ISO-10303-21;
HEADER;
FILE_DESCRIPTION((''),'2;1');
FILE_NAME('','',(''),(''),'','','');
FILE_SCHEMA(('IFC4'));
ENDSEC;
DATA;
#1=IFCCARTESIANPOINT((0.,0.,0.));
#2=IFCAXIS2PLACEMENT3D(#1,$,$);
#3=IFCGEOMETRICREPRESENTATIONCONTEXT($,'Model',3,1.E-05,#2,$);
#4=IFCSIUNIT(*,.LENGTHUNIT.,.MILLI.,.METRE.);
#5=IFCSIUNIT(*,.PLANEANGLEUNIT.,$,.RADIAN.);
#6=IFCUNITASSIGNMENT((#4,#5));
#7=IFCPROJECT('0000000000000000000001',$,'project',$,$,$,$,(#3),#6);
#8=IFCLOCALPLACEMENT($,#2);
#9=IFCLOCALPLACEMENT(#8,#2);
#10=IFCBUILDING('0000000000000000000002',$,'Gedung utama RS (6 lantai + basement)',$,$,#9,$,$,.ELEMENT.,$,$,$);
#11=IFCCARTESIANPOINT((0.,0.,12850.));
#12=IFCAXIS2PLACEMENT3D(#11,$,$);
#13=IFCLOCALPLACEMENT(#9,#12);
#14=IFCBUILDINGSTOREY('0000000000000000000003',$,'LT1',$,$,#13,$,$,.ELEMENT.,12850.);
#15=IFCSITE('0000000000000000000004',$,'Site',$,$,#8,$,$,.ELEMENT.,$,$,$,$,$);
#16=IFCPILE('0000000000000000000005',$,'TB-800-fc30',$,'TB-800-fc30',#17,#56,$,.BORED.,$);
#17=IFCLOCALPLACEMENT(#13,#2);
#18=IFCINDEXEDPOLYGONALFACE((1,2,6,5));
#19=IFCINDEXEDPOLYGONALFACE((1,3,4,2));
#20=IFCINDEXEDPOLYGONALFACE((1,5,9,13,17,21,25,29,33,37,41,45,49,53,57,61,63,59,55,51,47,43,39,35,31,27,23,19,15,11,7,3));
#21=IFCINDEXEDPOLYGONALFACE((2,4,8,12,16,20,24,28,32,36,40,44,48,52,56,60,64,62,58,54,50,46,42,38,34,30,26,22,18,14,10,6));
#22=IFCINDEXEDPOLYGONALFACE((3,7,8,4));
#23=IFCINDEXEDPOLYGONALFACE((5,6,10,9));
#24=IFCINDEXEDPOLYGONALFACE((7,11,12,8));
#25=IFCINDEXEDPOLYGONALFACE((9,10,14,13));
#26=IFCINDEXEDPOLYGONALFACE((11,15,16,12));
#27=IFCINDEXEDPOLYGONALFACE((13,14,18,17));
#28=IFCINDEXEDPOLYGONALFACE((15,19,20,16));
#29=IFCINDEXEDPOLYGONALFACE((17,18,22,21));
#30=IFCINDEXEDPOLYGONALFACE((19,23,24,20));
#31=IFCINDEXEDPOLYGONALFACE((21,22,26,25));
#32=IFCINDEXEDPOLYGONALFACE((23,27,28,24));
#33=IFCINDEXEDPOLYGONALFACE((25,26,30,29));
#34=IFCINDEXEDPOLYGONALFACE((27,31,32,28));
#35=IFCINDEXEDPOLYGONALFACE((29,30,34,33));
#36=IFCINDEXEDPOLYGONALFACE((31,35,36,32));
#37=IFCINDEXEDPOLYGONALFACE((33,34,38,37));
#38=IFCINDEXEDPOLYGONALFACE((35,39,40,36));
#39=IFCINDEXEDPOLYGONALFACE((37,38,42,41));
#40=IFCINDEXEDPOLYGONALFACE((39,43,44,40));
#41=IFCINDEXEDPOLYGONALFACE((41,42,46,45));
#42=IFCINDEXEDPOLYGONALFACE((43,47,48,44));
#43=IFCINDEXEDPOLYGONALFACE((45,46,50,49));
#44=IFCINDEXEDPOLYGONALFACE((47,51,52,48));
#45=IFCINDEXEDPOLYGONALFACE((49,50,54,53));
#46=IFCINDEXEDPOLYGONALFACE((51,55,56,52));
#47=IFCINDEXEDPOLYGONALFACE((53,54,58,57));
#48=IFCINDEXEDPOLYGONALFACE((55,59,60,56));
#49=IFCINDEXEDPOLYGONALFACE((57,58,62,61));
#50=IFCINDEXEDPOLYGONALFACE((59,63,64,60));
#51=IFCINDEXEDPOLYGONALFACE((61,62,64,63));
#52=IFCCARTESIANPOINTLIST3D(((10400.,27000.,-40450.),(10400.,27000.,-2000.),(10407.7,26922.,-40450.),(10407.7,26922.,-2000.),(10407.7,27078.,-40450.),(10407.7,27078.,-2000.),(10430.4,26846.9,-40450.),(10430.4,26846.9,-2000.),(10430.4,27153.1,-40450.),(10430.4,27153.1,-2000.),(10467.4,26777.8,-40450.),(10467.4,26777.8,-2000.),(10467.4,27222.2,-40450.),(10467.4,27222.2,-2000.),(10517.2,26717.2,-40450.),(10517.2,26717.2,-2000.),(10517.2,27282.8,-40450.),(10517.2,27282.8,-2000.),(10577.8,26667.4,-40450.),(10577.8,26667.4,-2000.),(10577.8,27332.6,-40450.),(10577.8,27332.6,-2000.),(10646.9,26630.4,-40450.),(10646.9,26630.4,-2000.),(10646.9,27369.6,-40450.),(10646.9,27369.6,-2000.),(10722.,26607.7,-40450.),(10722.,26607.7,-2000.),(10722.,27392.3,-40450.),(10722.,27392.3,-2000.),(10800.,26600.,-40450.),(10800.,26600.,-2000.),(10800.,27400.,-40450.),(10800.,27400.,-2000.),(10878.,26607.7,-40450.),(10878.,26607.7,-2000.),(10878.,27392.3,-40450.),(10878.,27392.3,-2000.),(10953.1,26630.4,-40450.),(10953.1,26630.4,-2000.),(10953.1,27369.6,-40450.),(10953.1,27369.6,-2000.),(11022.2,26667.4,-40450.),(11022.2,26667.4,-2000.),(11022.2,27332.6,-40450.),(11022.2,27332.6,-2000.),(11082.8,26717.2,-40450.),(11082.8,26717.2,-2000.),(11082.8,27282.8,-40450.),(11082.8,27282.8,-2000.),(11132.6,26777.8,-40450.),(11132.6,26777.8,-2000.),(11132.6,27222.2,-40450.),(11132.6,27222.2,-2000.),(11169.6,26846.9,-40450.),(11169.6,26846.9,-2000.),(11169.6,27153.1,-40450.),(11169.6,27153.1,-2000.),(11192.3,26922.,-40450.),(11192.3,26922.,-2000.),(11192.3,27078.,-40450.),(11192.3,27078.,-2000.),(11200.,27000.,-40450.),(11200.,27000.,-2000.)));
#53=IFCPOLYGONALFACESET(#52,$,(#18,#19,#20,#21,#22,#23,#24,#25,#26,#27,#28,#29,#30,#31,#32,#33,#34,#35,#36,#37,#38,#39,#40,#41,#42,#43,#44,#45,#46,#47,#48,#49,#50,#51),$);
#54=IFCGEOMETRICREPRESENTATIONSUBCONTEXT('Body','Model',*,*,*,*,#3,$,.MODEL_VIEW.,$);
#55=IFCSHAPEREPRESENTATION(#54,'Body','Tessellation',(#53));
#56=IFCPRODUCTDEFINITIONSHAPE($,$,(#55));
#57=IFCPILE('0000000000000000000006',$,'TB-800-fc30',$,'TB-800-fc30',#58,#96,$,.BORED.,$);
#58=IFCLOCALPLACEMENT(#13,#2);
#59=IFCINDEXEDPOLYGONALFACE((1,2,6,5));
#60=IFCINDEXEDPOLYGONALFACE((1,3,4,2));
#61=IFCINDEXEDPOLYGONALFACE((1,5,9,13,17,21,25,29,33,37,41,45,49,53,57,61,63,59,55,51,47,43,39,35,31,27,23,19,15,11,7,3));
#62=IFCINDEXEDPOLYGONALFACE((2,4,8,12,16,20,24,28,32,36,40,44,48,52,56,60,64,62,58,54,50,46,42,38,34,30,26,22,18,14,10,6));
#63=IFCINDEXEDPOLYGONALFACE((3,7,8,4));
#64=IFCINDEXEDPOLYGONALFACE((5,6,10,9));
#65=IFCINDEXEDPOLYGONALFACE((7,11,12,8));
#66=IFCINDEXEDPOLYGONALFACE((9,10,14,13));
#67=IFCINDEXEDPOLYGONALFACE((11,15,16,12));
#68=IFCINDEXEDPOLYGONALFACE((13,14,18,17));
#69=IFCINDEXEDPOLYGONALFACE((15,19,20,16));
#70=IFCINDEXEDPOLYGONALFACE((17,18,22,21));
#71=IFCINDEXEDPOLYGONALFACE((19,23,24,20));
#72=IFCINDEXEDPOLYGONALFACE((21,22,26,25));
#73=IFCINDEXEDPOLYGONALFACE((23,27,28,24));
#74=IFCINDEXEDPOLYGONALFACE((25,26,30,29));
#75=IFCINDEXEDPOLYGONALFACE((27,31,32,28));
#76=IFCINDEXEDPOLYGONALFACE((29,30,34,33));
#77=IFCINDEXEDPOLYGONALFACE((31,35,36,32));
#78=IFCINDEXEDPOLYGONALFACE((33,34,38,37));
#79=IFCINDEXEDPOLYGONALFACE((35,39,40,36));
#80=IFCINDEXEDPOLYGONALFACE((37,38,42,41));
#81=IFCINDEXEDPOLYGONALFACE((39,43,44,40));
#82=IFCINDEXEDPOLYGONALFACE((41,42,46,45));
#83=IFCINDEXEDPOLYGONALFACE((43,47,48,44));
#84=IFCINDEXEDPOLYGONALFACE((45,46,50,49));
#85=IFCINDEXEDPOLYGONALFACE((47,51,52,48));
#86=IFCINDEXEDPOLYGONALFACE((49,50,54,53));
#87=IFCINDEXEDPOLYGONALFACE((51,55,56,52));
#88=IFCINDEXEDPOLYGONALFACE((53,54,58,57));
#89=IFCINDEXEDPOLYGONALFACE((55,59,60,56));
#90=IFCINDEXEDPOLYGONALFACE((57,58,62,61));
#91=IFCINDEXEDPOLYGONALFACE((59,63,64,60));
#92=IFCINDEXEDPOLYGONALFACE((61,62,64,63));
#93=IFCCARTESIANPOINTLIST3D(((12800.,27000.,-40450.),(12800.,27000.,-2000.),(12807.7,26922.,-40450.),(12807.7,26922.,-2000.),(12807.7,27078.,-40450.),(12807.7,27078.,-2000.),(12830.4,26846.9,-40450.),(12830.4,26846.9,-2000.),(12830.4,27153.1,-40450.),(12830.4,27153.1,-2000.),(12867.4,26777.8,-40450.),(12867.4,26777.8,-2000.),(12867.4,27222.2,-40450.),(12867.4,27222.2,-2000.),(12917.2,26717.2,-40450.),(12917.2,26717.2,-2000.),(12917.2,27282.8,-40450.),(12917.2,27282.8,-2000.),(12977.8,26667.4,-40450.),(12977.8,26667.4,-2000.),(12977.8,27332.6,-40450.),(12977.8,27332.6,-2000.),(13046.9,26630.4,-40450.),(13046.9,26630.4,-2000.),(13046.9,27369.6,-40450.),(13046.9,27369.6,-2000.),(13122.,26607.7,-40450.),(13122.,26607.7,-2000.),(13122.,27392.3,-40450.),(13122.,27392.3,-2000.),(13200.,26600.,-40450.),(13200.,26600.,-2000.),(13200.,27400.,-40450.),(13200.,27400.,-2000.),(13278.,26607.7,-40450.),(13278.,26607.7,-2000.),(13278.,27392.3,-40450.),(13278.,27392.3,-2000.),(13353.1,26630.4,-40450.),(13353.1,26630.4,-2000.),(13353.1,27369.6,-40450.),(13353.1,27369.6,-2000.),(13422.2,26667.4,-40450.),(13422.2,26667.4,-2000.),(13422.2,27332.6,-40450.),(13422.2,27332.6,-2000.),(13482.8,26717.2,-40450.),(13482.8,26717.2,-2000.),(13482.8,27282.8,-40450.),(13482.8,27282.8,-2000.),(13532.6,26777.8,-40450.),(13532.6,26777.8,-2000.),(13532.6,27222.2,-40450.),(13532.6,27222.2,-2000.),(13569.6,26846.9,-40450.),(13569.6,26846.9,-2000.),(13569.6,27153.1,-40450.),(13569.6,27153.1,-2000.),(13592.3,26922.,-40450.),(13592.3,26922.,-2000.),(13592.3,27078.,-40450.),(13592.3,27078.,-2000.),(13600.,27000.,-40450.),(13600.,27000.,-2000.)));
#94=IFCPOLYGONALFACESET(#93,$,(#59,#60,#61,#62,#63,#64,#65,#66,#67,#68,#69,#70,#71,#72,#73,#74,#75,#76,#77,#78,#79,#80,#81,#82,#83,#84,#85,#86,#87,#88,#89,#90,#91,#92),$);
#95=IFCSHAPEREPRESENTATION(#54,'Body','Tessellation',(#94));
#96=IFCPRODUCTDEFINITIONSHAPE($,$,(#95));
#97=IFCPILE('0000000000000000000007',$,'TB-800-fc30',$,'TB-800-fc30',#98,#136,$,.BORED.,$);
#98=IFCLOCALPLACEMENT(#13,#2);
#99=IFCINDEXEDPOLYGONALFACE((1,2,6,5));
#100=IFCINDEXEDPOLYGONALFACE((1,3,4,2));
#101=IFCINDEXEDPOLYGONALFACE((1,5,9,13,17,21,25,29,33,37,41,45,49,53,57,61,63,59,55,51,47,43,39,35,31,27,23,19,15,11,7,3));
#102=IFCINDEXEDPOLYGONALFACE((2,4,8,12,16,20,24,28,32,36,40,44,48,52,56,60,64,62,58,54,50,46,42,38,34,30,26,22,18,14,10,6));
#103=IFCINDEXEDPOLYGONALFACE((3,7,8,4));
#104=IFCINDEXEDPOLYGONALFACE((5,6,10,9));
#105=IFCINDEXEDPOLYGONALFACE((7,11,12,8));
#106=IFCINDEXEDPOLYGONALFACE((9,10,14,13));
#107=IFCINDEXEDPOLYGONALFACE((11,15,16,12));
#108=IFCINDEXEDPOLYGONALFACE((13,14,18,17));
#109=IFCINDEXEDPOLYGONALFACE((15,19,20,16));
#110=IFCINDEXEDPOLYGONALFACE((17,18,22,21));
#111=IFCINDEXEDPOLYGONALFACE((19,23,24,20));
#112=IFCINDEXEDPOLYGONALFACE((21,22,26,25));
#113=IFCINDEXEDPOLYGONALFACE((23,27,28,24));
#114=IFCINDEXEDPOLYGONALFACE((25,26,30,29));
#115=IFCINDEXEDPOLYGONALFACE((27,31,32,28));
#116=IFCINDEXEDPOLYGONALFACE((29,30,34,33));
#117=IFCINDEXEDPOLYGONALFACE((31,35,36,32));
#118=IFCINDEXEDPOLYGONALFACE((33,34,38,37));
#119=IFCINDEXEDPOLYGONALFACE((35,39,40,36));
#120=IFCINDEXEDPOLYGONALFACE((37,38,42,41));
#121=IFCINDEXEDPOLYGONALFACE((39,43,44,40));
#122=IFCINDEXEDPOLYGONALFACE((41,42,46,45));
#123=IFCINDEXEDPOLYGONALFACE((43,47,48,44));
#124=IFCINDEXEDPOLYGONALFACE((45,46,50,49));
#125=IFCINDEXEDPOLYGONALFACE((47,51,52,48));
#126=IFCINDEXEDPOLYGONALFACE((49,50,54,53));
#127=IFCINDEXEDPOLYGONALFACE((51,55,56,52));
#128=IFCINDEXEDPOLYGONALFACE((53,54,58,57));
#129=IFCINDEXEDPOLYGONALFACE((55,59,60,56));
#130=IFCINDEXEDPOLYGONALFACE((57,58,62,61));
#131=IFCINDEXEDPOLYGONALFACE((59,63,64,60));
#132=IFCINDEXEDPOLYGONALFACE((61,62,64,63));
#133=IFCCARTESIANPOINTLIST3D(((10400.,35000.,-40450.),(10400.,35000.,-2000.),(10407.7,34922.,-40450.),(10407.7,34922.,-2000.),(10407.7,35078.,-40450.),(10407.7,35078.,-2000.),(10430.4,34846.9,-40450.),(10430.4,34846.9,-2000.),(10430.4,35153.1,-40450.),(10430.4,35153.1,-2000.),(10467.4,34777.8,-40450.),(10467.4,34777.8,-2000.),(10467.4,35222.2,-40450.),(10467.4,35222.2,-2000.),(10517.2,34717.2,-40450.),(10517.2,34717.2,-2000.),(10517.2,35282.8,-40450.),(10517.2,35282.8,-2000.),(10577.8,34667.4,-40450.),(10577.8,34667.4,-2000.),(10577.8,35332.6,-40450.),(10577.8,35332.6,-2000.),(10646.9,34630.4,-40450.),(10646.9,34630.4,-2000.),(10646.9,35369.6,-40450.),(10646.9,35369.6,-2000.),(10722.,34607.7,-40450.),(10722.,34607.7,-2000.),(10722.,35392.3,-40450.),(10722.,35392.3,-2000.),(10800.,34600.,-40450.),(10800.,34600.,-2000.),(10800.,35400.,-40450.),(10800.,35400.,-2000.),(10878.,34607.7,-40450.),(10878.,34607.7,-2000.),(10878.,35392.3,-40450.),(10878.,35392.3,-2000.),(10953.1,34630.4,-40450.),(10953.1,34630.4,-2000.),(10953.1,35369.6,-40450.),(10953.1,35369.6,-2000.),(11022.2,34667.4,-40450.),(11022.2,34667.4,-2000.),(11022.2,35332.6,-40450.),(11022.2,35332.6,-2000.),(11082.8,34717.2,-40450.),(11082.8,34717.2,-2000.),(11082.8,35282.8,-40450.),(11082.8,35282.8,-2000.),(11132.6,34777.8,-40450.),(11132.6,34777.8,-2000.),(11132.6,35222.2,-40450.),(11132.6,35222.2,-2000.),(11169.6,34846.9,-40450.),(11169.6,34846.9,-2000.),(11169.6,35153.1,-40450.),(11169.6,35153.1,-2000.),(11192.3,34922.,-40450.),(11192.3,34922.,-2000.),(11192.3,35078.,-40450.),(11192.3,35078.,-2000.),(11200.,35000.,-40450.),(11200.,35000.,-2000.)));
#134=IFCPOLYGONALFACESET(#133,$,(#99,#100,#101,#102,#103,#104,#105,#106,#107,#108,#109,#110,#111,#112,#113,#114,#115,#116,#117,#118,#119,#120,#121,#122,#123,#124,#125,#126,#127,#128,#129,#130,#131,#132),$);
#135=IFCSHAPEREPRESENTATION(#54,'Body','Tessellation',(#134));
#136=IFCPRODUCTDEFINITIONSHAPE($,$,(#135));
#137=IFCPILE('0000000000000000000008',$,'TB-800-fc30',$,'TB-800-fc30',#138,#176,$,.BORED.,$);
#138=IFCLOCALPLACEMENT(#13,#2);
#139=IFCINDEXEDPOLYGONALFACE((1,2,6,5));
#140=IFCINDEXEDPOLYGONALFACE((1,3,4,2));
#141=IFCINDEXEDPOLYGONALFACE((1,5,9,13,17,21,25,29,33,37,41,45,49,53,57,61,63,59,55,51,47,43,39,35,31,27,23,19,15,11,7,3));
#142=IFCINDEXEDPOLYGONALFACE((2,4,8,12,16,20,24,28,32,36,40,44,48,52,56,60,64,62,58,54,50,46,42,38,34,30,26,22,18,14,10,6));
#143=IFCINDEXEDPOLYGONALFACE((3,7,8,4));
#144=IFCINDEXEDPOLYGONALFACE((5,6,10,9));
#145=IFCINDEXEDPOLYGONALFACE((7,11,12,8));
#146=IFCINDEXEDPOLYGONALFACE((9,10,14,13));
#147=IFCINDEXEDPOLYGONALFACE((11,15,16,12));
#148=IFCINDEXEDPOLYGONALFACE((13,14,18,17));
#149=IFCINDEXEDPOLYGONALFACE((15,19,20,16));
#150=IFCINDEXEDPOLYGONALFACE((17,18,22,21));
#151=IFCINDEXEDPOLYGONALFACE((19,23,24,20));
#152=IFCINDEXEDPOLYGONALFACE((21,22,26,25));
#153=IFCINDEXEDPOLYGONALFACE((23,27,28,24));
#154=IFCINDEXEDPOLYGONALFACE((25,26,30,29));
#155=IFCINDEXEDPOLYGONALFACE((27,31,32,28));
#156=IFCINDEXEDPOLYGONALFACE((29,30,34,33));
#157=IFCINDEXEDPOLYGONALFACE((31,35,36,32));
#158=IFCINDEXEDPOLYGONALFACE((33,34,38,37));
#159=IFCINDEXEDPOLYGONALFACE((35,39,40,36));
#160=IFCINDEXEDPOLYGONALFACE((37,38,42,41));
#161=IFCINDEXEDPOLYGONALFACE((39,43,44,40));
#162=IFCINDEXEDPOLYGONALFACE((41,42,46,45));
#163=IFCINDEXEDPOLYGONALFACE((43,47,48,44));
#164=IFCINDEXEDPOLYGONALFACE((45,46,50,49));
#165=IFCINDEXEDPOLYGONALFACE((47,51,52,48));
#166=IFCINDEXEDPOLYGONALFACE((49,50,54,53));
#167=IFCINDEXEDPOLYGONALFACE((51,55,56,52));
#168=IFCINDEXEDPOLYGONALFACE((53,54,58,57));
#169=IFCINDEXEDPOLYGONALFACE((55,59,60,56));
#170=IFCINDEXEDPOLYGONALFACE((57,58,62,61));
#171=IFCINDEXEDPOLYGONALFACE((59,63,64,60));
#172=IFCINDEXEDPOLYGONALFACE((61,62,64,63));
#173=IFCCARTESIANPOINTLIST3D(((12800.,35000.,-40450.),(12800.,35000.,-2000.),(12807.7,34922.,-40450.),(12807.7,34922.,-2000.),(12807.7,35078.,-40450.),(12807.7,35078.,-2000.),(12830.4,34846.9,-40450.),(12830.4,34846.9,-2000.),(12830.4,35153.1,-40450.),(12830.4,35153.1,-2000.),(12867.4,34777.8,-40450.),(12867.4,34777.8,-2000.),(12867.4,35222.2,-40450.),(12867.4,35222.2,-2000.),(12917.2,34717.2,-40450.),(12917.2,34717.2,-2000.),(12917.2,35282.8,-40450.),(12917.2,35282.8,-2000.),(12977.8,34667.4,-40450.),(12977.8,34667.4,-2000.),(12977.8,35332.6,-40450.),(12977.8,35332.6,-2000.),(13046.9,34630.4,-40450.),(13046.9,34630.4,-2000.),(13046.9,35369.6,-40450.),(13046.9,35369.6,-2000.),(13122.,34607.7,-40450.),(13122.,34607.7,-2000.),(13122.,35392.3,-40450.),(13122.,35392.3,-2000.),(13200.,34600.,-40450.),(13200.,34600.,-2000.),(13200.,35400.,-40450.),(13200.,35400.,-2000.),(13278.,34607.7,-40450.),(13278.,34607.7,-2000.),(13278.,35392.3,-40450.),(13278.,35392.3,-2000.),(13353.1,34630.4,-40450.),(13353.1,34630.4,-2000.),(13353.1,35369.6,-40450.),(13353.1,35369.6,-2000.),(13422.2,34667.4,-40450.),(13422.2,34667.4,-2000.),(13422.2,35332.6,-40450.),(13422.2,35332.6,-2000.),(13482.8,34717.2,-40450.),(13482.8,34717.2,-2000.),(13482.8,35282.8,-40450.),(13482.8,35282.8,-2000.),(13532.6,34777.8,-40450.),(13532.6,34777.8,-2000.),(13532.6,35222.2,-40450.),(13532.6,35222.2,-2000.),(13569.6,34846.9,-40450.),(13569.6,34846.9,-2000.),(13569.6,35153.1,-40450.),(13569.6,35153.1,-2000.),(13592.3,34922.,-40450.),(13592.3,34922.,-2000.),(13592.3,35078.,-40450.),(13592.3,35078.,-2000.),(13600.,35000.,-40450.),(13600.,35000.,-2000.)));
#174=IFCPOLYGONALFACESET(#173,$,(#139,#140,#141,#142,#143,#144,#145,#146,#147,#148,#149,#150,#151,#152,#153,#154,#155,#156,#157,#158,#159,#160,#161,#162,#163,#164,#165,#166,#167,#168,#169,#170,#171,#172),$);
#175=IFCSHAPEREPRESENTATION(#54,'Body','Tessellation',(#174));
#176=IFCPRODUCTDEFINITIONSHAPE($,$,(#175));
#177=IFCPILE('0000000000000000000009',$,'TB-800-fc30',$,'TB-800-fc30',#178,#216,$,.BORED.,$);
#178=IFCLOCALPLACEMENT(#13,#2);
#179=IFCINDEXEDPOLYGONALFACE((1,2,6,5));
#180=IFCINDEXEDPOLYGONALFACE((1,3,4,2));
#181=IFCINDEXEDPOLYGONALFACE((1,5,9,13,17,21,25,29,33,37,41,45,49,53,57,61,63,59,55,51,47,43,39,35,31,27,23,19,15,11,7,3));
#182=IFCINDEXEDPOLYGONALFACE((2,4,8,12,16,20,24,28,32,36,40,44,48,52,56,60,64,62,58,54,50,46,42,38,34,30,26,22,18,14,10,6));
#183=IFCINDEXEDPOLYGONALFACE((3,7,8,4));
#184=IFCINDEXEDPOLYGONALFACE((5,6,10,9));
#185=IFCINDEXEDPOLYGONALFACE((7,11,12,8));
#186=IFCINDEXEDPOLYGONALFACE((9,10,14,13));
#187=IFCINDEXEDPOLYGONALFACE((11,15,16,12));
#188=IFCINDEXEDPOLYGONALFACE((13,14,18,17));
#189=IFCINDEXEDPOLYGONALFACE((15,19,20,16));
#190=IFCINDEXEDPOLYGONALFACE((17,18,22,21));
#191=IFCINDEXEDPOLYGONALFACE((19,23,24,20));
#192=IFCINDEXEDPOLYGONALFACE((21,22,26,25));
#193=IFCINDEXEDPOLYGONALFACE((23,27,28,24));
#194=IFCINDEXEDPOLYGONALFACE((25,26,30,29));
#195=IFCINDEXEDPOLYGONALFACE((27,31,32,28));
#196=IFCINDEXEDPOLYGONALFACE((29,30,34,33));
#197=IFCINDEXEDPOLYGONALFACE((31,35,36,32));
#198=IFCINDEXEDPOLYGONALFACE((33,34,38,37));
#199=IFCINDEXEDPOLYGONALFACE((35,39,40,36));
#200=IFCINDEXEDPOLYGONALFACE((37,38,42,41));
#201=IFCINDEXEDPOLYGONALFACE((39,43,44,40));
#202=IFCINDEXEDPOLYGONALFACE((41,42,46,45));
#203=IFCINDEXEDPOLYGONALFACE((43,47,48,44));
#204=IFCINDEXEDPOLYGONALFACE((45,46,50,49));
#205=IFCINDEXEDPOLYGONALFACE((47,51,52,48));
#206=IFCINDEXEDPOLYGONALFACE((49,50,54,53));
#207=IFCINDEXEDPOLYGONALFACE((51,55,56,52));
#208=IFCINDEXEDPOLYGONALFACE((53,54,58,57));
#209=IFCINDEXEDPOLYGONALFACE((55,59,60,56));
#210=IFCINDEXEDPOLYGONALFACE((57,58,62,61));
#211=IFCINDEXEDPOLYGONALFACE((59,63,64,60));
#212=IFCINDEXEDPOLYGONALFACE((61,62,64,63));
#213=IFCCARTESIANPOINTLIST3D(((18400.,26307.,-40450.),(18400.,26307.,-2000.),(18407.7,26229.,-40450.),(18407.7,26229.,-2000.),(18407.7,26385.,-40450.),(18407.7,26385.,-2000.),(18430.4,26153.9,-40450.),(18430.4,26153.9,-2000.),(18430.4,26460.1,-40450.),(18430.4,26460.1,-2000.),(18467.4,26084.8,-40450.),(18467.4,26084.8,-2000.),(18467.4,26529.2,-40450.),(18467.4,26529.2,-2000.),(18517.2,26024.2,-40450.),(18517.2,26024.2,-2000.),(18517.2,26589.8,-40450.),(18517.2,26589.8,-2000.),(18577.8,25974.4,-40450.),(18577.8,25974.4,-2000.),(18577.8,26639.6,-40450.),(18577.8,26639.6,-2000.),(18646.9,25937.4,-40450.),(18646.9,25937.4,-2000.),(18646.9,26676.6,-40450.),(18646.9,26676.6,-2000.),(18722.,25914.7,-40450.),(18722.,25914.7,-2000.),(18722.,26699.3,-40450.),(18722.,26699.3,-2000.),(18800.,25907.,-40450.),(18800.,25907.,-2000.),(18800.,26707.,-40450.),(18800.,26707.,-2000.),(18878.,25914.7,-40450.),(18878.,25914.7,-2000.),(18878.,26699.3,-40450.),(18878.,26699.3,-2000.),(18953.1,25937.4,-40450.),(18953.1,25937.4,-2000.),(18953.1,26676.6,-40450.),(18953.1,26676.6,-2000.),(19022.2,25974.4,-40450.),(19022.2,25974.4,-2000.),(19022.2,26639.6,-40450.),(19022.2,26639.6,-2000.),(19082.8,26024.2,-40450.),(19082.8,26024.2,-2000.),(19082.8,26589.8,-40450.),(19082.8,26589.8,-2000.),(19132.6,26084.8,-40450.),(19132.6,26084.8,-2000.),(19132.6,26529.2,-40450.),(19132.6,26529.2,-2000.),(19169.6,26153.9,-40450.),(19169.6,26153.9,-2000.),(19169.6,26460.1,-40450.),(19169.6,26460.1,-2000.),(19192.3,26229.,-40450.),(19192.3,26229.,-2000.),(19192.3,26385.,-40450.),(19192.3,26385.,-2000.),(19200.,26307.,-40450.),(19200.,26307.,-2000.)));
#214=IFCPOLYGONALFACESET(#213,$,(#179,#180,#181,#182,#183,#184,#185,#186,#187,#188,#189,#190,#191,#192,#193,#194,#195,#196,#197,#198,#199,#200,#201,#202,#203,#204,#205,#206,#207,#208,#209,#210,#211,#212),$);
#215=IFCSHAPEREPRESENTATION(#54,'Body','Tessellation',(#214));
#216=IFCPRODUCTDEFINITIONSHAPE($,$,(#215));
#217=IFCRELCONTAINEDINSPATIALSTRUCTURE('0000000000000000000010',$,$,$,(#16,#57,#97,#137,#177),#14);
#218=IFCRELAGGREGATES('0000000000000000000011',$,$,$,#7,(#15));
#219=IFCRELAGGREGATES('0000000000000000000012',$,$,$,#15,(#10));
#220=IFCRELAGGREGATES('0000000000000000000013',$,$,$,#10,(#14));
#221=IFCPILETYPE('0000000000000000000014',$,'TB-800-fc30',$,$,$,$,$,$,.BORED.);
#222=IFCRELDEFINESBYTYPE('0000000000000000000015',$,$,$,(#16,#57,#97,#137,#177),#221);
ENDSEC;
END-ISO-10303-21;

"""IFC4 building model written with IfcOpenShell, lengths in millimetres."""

from ifc_helpers import new_model, si_unit, frame, origin, origin_2d, place, context, subcontext, project, spatial, circle, extrude, material_profile, profile_set, profile_usage, type_object, element, save


model = new_model("IFC4")

# Units and contexts
model_context = context("Model", 3, precision=1e-05, world=origin())
body_context = subcontext(model_context, "Body", "Model", "MODEL_VIEW")
ifc_project = project(units=[si_unit("LENGTHUNIT", "METRE", prefix="MILLI"), si_unit("PLANEANGLEUNIT", "RADIAN")], contexts=[model_context])

# Site, building, storey
site_placement = place(None, origin())
site = spatial("IfcSite", under=ifc_project, at=site_placement, Name="Site", CompositionType="ELEMENT")
building_placement = place(site_placement, origin())
building = spatial("IfcBuilding", under=site, at=building_placement, Name="Gedung utama RS (6 lantai + basement)", CompositionType="ELEMENT")
storey_placement = place(building_placement, frame((0.0, 0.0, 12850.0)))
storey = spatial("IfcBuildingStorey", under=building, at=storey_placement, Name="LT1", CompositionType="ELEMENT", Elevation=12850.0)

# Piles
ifc_material_profile_1 = material_profile(None, circle(Radius=400.0, at=origin_2d()), Name="TB-800-fc30")
ifc_profile_set_1 = profile_set([ifc_material_profile_1], Name="TB-800-fc30")
ifc_profile_usage_1 = profile_usage(ifc_profile_set_1, cardinal=5)
pile_type = type_object("IfcPileType", Name="TB-800-fc30", PredefinedType="BORED", material=ifc_profile_set_1)
for number, where, z_axis, x_axis, name in (
    (1, (10800.0, 27000.0, -40450.0), (0.0, 0.0, 1.0), (1.0, 0.0, 0.0), "TB-800-fc30"),
    (2, (13200.0, 27000.0, -40450.0), (0.0, 0.0, 1.0), (1.0, 0.0, 0.0), "TB-800-fc30"),
    (3, (10800.0, 35000.0, -40450.0), (0.0, 0.0, 1.0), (1.0, 0.0, 0.0), "TB-800-fc30"),
    (4, (13200.0, 35000.0, -40450.0), (0.0, 0.0, 1.0), (1.0, 0.0, 0.0), "TB-800-fc30"),
    (5, (18800.0, 26307.0, -40450.0), (0.0, 0.0, 1.0), (1.0, 0.0, 0.0), "TB-800-fc30"),
):
    element("IfcPile", number, at=place(storey_placement, frame(where, z_axis=z_axis, x_axis=x_axis)), inside=storey, type_object=pile_type, material=ifc_profile_usage_1, Name=name, ObjectType="TB-800-fc30", PredefinedType="BORED", context=body_context, shape_type="SweptSolid", body=[
        extrude(circle(Radius=400.0, at=origin_2d()), origin(), (0.0, 0.0, 1.0), 38450.0),
    ])

save(model, "model.ifc")
